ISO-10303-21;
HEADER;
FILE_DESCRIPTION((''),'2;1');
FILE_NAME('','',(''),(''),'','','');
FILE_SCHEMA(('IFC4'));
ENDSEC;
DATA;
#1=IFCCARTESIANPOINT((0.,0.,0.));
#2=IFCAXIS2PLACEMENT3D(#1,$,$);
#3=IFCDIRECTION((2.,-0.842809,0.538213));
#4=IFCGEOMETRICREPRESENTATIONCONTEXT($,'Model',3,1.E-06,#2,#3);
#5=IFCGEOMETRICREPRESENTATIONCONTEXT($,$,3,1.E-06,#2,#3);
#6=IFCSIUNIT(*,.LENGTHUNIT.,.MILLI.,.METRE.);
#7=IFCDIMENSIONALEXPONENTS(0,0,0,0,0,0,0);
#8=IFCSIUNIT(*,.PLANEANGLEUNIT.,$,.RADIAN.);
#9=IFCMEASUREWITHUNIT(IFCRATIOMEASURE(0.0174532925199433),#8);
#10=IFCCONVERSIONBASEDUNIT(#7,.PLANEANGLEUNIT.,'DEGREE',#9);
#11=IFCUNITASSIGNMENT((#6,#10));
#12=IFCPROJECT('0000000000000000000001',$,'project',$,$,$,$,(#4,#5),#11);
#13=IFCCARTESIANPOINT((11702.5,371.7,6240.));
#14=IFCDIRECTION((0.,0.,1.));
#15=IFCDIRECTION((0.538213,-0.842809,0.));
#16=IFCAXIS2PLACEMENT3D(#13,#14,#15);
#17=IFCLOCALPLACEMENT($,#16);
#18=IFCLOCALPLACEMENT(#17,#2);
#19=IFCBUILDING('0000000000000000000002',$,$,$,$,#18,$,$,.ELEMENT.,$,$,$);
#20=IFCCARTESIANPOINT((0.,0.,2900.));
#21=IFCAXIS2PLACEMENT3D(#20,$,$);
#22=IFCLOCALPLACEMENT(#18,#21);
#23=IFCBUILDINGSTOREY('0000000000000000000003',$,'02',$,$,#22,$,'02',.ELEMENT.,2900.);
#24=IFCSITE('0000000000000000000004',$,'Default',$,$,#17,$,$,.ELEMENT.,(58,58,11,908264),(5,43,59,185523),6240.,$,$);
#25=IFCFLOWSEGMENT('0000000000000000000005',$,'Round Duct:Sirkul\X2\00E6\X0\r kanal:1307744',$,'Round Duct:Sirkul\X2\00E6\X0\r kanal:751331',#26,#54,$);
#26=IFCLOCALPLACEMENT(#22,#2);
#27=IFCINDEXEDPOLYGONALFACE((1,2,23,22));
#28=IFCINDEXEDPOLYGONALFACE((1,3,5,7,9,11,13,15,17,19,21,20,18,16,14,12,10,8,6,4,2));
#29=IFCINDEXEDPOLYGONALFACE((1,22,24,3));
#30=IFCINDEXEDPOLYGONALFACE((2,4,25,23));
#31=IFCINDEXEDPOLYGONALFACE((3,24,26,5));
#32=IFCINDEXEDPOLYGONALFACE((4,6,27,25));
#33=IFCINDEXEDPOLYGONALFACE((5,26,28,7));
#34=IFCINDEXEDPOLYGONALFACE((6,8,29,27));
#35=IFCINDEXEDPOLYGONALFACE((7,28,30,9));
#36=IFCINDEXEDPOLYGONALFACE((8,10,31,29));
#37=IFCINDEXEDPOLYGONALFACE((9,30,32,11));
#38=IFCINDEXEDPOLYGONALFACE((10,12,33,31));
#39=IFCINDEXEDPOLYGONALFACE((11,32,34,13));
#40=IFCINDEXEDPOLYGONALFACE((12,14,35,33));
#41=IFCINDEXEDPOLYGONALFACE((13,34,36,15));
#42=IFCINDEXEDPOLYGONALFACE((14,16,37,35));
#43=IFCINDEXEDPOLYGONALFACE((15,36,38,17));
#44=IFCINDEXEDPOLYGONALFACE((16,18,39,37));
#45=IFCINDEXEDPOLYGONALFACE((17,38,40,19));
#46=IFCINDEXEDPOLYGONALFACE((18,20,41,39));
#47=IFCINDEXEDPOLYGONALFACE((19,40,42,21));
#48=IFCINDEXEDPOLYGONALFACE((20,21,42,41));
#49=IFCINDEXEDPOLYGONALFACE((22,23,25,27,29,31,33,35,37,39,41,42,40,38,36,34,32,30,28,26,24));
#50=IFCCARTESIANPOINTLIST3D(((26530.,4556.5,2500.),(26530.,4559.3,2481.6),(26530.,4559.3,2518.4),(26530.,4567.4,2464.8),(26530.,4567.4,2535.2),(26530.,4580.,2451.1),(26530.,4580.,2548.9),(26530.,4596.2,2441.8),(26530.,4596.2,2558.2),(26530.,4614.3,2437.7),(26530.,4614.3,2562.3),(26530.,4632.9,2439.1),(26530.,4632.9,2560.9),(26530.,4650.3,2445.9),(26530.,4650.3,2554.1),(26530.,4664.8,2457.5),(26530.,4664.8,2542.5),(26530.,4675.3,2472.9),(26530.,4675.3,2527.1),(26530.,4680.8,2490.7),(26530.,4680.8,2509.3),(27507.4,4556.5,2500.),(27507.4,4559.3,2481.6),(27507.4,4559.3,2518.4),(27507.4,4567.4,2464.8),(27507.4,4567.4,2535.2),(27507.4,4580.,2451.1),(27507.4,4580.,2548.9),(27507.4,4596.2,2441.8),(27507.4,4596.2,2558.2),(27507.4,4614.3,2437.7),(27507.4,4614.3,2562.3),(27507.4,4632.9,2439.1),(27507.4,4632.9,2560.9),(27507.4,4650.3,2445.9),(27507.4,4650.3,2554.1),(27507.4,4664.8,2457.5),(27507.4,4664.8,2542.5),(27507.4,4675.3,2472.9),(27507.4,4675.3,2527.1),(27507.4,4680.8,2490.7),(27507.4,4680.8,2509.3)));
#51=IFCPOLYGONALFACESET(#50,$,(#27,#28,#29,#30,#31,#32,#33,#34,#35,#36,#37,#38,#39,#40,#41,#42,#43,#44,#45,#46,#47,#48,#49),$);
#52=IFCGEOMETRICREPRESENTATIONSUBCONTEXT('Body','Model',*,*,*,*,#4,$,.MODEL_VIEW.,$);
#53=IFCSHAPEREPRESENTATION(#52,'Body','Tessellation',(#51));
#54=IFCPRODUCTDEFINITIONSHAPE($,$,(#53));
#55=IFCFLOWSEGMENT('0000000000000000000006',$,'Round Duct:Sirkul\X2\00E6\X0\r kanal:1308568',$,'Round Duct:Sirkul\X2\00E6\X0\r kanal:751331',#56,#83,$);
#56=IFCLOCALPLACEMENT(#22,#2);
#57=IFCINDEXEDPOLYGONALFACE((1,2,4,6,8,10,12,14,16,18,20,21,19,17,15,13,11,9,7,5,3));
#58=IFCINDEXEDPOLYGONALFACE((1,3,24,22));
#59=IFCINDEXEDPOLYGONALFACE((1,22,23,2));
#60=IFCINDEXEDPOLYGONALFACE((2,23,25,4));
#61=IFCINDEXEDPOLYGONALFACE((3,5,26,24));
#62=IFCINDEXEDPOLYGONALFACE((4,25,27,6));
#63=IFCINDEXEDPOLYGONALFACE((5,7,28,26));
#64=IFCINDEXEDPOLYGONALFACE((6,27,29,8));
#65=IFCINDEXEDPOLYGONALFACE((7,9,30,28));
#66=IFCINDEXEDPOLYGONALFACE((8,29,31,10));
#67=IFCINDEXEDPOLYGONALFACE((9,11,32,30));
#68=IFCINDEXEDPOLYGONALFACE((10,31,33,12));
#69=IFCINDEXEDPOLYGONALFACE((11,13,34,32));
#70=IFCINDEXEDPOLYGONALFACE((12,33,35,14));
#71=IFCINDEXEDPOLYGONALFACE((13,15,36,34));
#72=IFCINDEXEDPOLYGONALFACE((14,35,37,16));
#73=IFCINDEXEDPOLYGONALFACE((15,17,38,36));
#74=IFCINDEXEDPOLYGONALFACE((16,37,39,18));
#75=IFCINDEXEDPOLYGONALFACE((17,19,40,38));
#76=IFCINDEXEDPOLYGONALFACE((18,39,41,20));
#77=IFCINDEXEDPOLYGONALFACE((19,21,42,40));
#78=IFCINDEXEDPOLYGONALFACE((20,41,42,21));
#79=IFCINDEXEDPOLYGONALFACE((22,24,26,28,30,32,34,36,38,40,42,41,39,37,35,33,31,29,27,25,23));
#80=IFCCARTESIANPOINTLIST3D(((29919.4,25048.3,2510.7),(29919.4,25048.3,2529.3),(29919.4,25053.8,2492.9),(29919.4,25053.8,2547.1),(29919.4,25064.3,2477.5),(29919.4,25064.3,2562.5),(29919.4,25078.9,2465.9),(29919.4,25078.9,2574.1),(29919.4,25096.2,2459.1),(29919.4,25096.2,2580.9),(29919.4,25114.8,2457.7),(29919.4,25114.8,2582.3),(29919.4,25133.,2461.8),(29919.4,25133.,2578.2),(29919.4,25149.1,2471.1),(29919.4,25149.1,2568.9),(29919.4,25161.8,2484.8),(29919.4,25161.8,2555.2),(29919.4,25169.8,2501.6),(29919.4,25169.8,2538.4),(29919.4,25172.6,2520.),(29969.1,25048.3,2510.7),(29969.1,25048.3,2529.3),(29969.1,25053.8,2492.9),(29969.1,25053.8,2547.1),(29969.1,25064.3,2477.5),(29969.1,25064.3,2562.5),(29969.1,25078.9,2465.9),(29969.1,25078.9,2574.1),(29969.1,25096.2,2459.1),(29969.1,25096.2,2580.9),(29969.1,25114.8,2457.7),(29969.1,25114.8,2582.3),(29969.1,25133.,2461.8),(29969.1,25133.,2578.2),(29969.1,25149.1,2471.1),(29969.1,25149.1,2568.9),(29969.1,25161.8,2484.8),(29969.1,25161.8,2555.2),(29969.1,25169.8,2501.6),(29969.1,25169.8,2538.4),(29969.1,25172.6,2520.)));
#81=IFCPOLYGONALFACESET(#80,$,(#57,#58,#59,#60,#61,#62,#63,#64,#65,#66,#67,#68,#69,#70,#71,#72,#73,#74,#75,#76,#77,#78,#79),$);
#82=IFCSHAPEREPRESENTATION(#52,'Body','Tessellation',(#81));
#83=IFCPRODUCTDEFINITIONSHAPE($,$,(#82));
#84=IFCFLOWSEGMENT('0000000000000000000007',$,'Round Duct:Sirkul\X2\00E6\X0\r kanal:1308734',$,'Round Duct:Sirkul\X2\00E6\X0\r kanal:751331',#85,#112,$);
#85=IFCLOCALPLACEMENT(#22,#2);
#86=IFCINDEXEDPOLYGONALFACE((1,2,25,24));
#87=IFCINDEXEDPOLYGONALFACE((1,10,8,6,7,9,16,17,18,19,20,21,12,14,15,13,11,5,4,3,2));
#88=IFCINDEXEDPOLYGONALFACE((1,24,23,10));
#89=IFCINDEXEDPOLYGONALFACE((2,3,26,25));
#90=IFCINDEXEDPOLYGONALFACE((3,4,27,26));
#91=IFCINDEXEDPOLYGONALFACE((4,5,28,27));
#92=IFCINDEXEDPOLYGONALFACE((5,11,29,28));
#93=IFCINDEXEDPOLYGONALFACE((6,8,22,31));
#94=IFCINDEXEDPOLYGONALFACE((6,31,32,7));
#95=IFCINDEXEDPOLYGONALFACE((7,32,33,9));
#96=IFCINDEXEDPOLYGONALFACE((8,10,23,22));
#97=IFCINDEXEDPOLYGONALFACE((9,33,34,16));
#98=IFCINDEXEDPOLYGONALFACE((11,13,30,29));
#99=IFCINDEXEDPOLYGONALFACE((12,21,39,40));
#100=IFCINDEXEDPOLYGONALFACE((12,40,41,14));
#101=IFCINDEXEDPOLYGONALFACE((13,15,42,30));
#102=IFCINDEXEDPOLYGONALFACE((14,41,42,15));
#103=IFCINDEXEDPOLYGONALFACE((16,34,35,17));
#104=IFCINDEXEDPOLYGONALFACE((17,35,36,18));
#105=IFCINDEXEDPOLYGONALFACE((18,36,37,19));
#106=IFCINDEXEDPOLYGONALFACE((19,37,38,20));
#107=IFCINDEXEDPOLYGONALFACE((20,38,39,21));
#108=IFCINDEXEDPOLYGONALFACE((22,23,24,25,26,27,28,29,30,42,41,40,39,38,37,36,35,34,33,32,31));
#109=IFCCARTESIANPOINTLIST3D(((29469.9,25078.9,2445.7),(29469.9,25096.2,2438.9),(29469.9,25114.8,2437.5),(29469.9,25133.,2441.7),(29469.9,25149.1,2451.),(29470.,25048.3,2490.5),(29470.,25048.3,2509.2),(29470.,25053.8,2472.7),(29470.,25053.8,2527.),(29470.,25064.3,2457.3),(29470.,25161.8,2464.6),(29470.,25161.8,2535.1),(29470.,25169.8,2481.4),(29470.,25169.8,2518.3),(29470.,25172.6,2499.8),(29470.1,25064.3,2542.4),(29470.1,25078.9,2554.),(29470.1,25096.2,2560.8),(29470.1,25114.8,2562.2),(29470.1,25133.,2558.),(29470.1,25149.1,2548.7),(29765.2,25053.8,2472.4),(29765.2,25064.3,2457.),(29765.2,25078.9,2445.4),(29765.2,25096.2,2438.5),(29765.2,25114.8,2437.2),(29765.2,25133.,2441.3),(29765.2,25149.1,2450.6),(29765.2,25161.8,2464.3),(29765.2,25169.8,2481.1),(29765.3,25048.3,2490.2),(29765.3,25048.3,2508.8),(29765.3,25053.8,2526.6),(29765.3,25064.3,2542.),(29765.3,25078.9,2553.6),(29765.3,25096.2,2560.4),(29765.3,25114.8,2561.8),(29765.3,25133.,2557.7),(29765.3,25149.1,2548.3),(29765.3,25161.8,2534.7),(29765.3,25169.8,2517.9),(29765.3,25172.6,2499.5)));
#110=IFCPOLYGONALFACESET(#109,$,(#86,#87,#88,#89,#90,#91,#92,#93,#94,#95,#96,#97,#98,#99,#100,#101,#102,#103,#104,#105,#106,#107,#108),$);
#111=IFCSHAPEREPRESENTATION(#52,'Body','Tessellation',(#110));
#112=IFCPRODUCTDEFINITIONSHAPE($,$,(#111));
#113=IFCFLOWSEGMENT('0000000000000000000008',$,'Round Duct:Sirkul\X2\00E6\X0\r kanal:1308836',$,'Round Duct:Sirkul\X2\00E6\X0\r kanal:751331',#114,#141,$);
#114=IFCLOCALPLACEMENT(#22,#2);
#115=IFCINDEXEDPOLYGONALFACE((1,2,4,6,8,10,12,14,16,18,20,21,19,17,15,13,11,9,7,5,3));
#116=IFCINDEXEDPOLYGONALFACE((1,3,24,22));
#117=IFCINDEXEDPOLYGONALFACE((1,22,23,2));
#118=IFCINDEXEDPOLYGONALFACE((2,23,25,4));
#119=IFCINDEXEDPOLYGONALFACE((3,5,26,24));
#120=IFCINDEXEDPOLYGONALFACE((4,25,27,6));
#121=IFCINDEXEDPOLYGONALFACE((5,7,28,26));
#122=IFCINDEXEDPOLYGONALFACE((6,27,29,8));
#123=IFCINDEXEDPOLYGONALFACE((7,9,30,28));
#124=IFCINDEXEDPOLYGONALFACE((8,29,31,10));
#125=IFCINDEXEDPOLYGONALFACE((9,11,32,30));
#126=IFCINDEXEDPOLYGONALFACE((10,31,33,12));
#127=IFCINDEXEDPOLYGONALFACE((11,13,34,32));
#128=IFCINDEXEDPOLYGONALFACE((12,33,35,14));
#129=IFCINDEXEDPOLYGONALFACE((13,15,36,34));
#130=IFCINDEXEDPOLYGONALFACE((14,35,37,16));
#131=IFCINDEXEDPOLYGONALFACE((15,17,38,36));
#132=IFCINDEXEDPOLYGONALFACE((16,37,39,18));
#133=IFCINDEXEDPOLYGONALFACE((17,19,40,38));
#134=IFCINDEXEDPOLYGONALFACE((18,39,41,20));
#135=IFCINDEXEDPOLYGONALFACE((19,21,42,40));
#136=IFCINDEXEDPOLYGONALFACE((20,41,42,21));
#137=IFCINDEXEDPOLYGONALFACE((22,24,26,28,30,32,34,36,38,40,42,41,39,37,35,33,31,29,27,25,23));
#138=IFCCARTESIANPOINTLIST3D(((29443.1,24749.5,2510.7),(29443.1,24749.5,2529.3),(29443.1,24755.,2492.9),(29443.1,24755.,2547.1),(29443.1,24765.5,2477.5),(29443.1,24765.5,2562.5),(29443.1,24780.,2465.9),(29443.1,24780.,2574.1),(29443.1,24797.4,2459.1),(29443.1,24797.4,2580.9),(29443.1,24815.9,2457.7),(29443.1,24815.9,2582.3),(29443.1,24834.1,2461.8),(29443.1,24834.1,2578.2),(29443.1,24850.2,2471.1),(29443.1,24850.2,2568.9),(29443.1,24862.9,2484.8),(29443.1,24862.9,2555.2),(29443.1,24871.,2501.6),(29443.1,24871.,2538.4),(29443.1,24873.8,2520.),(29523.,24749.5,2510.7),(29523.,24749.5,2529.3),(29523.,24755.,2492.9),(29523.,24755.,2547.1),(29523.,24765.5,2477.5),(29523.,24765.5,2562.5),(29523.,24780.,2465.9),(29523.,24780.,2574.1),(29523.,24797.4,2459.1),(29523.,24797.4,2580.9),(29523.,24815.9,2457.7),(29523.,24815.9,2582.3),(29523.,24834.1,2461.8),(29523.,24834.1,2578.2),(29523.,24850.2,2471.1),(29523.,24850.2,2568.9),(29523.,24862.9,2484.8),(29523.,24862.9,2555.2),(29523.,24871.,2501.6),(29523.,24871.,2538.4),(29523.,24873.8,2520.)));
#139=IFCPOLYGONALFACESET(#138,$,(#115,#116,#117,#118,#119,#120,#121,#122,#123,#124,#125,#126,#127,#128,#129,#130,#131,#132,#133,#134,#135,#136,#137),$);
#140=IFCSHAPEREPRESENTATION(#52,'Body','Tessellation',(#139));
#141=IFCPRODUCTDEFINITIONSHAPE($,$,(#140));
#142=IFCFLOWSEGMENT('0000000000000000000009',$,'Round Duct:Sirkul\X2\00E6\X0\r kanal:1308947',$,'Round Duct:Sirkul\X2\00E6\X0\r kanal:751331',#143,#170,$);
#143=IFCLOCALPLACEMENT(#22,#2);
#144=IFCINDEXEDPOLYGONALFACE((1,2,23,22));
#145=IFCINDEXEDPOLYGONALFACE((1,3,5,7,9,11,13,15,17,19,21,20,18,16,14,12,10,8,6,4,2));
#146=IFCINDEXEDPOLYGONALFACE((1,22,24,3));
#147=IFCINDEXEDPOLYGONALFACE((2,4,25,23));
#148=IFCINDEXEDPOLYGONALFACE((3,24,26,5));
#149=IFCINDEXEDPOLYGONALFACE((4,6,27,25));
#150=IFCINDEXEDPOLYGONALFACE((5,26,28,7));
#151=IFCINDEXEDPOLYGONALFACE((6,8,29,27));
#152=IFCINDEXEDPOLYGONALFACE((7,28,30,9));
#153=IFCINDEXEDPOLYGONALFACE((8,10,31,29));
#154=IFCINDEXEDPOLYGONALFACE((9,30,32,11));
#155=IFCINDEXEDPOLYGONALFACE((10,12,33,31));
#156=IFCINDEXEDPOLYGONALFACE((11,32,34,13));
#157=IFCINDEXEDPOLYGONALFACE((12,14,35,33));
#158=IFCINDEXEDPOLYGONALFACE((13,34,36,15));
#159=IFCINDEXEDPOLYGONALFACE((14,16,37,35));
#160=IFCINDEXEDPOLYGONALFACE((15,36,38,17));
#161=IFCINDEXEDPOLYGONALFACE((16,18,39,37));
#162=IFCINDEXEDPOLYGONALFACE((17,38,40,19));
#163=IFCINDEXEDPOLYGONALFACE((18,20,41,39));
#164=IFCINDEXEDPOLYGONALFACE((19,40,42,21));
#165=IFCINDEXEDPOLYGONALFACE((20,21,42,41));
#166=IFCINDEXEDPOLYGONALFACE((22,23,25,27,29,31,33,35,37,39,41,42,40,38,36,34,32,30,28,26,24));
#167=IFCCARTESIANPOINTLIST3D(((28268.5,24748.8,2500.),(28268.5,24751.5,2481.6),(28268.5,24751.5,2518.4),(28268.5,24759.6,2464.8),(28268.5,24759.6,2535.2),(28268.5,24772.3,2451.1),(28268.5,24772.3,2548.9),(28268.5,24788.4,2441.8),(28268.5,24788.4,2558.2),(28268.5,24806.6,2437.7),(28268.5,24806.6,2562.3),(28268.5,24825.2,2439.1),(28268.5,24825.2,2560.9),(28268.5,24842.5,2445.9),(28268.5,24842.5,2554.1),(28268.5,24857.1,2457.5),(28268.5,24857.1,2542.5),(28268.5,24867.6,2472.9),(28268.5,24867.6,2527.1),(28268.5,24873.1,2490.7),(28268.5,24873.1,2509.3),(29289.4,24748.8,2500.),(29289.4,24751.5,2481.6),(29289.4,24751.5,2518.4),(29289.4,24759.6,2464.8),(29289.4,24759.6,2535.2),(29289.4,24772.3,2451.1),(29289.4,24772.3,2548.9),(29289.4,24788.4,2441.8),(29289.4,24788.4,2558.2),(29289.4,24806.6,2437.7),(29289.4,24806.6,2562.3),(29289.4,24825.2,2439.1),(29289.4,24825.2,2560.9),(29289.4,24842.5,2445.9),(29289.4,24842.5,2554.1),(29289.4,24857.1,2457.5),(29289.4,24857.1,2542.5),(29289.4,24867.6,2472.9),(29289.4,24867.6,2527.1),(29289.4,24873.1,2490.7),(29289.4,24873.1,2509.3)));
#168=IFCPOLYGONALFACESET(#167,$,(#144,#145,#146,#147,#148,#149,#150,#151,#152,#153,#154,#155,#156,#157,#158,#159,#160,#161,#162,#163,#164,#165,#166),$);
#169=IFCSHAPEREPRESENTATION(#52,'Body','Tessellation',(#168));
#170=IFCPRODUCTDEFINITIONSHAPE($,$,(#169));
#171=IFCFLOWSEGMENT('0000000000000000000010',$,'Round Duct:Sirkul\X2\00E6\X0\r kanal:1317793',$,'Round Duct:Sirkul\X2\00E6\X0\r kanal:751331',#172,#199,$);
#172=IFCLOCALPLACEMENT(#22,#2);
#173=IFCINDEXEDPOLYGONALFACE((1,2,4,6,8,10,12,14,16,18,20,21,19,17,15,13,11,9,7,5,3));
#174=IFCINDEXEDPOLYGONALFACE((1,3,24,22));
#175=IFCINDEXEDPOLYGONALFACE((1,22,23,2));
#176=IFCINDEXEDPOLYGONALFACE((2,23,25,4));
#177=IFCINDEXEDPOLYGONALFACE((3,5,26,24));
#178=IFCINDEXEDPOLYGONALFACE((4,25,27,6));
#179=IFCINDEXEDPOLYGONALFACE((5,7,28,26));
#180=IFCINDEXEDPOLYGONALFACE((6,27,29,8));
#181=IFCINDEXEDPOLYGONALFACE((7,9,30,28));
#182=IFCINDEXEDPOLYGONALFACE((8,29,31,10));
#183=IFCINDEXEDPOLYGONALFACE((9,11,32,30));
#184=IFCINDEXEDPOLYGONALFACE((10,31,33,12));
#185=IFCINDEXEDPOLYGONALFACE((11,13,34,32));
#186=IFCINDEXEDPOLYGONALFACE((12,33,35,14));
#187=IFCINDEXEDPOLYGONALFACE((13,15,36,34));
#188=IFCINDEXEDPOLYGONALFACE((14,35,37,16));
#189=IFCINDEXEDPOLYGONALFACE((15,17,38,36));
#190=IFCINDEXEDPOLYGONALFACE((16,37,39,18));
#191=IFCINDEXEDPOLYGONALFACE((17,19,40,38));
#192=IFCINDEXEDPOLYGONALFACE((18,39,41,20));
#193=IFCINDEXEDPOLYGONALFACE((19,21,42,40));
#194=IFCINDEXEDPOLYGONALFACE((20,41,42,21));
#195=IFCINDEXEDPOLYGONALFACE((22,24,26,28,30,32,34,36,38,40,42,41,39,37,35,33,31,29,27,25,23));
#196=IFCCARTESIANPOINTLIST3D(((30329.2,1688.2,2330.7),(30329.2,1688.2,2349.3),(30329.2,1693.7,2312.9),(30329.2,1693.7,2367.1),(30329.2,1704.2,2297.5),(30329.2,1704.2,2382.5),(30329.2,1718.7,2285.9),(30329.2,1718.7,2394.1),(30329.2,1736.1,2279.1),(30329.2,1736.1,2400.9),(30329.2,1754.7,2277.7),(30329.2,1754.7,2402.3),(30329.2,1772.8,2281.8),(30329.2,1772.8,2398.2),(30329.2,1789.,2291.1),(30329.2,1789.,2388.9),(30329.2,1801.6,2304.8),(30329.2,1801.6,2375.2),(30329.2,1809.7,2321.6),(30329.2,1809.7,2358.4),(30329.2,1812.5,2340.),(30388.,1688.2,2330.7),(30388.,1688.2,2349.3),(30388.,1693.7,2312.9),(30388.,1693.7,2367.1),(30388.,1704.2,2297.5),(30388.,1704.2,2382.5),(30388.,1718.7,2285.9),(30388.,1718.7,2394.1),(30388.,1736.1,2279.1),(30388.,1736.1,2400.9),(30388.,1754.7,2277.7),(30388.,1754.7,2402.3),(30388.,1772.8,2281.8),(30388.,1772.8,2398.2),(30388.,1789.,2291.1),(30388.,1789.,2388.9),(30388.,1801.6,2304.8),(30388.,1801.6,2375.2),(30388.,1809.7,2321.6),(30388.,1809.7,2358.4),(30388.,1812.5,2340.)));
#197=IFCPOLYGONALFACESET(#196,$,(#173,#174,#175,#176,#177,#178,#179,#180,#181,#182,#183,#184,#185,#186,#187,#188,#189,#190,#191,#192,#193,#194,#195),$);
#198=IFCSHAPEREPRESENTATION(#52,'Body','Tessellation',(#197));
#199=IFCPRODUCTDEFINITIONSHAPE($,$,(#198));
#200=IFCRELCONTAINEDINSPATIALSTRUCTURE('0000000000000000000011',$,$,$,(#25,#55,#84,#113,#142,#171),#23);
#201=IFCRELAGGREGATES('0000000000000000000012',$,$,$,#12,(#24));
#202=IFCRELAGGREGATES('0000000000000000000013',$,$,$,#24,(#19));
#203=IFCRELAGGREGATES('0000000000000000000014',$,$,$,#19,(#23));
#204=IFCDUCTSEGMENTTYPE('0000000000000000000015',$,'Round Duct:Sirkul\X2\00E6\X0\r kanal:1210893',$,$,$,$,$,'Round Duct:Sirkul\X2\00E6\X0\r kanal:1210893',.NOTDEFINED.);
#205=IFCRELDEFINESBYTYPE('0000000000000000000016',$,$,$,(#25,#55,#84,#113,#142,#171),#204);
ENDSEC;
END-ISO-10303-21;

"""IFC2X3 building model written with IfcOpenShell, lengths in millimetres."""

from ifc_helpers import new_model, entity, si_unit, converted_unit, direction, frame, frame_2d, origin, origin_2d_with_axis, place, context, subcontext, project, spatial, circle, extrude, type_object, element, save


model = new_model("IFC2X3")

# Units and contexts
model_context = context("Model", 3, precision=1e-06, world=origin(), true_north=direction((2.0, -0.842809, 0.538213)))
context_of_model = context(None, 3, precision=1e-06, world=origin(), true_north=direction((2.0, -0.842809, 0.538213)))
body_context = subcontext(model_context, "Body", "Model", "MODEL_VIEW")
ifc_project = project(units=[si_unit("LENGTHUNIT", "METRE", prefix="MILLI"), converted_unit("PLANEANGLEUNIT", "DEGREE", entity("IfcRatioMeasure", 0.0174532925199433), si_unit("PLANEANGLEUNIT", "RADIAN"), dimensions=[0, 0, 0, 0, 0, 0, 0])], contexts=[model_context, context_of_model])

# Site, building, storey
site_placement = place(None, frame((11702.5, 371.7, 6240.0), z_axis=(0.0, 0.0, 1.0), x_axis=(0.538213, -0.842809, 0.0)))
site = spatial("IfcSite", under=ifc_project, at=site_placement, Name="Default", CompositionType="ELEMENT", RefLatitude=(58, 58, 11, 908264), RefLongitude=(5, 43, 59, 185523), RefElevation=6240.0)
building_placement = place(site_placement, origin())
building = spatial("IfcBuilding", under=site, at=building_placement, CompositionType="ELEMENT")
storey_placement = place(building_placement, frame((0.0, 0.0, 2900.0)))
storey = spatial("IfcBuildingStorey", under=building, at=storey_placement, Name="02", LongName="02", CompositionType="ELEMENT", Elevation=2900.0)

# Flow segments
duct_segment_type_1 = type_object("IfcDuctSegmentType", Name="Round Duct:Sirkulær kanal:1210893", ElementType="Round Duct:Sirkulær kanal:1210893", PredefinedType="NOTDEFINED")
flow_segment_1_placement = place(storey_placement, origin())
element("IfcFlowSegment", 1, at=flow_segment_1_placement, inside=storey, type_object=duct_segment_type_1, Name="Round Duct:Sirkulær kanal:1307744", ObjectType="Round Duct:Sirkulær kanal:751331", context=body_context, shape_type="SweptSolid", body=[
    extrude(circle(Radius=62.5, at=frame_2d((0.0, 0.0), x_axis=(1.0, 0.0))), frame((26530.0, 4619.0, 2500.0), z_axis=(1.0, 0.0, 0.0), x_axis=(0.0, -1.0, 0.0)), (0.0, 0.0, 1.0), 977.4),
])
flow_segment_2_placement = place(storey_placement, origin())
element("IfcFlowSegment", 2, at=flow_segment_2_placement, inside=storey, type_object=duct_segment_type_1, Name="Round Duct:Sirkulær kanal:1308568", ObjectType="Round Duct:Sirkulær kanal:751331", context=body_context, shape_type="SweptSolid", body=[
    extrude(circle(Radius=62.5, at=frame_2d((0.0, 0.0), x_axis=(1.0, 0.0))), frame((29919.4, 25110.1, 2520.0), z_axis=(1.0, 0.0, 0.0), x_axis=(0.0, 1.0, 0.0)), (0.0, 0.0, 1.0), 49.6),
])
flow_segment_3_placement = place(storey_placement, origin())
element("IfcFlowSegment", 3, at=flow_segment_3_placement, inside=storey, type_object=duct_segment_type_1, Name="Round Duct:Sirkulær kanal:1308734", ObjectType="Round Duct:Sirkulær kanal:751331", context=body_context, shape_type="SweptSolid", body=[
    extrude(circle(Radius=62.5, at=frame_2d((0.0, 0.0), x_axis=(1.0, 0.0))), frame((29470.0, 25110.1, 2499.8), z_axis=(0.999999, 0.0, -0.001244), x_axis=(0.0, 1.0, 0.0)), (0.0, 0.0, 1.0), 295.3),
])
flow_segment_4_placement = place(storey_placement, origin())
element("IfcFlowSegment", 4, at=flow_segment_4_placement, inside=storey, type_object=duct_segment_type_1, Name="Round Duct:Sirkulær kanal:1308836", ObjectType="Round Duct:Sirkulær kanal:751331", context=body_context, shape_type="SweptSolid", body=[
    extrude(circle(Radius=62.5, at=origin_2d_with_axis()), frame((29443.1, 24811.3, 2520.0), z_axis=(1.0, 0.0, 0.0), x_axis=(0.0, 1.0, 0.0)), (0.0, 0.0, 1.0), 79.9),
])
flow_segment_5_placement = place(storey_placement, origin())
element("IfcFlowSegment", 5, at=flow_segment_5_placement, inside=storey, type_object=duct_segment_type_1, Name="Round Duct:Sirkulær kanal:1308947", ObjectType="Round Duct:Sirkulær kanal:751331", context=body_context, shape_type="SweptSolid", body=[
    extrude(circle(Radius=62.5, at=origin_2d_with_axis()), frame((28268.5, 24811.3, 2500.0), z_axis=(1.0, 0.0, 0.0), x_axis=(0.0, -1.0, 0.0)), (0.0, 0.0, 1.0), 1020.9),
])
flow_segment_6_placement = place(storey_placement, origin())
element("IfcFlowSegment", 6, at=flow_segment_6_placement, inside=storey, type_object=duct_segment_type_1, Name="Round Duct:Sirkulær kanal:1317793", ObjectType="Round Duct:Sirkulær kanal:751331", context=body_context, shape_type="SweptSolid", body=[
    extrude(circle(Radius=62.5, at=frame_2d((0.0, 0.0), x_axis=(1.0, 0.0))), frame((30329.2, 1750.0, 2340.0), z_axis=(1.0, 0.0, 0.0), x_axis=(0.0, 1.0, 0.0)), (0.0, 0.0, 1.0), 58.8),
])

save(model, "model.ifc")
